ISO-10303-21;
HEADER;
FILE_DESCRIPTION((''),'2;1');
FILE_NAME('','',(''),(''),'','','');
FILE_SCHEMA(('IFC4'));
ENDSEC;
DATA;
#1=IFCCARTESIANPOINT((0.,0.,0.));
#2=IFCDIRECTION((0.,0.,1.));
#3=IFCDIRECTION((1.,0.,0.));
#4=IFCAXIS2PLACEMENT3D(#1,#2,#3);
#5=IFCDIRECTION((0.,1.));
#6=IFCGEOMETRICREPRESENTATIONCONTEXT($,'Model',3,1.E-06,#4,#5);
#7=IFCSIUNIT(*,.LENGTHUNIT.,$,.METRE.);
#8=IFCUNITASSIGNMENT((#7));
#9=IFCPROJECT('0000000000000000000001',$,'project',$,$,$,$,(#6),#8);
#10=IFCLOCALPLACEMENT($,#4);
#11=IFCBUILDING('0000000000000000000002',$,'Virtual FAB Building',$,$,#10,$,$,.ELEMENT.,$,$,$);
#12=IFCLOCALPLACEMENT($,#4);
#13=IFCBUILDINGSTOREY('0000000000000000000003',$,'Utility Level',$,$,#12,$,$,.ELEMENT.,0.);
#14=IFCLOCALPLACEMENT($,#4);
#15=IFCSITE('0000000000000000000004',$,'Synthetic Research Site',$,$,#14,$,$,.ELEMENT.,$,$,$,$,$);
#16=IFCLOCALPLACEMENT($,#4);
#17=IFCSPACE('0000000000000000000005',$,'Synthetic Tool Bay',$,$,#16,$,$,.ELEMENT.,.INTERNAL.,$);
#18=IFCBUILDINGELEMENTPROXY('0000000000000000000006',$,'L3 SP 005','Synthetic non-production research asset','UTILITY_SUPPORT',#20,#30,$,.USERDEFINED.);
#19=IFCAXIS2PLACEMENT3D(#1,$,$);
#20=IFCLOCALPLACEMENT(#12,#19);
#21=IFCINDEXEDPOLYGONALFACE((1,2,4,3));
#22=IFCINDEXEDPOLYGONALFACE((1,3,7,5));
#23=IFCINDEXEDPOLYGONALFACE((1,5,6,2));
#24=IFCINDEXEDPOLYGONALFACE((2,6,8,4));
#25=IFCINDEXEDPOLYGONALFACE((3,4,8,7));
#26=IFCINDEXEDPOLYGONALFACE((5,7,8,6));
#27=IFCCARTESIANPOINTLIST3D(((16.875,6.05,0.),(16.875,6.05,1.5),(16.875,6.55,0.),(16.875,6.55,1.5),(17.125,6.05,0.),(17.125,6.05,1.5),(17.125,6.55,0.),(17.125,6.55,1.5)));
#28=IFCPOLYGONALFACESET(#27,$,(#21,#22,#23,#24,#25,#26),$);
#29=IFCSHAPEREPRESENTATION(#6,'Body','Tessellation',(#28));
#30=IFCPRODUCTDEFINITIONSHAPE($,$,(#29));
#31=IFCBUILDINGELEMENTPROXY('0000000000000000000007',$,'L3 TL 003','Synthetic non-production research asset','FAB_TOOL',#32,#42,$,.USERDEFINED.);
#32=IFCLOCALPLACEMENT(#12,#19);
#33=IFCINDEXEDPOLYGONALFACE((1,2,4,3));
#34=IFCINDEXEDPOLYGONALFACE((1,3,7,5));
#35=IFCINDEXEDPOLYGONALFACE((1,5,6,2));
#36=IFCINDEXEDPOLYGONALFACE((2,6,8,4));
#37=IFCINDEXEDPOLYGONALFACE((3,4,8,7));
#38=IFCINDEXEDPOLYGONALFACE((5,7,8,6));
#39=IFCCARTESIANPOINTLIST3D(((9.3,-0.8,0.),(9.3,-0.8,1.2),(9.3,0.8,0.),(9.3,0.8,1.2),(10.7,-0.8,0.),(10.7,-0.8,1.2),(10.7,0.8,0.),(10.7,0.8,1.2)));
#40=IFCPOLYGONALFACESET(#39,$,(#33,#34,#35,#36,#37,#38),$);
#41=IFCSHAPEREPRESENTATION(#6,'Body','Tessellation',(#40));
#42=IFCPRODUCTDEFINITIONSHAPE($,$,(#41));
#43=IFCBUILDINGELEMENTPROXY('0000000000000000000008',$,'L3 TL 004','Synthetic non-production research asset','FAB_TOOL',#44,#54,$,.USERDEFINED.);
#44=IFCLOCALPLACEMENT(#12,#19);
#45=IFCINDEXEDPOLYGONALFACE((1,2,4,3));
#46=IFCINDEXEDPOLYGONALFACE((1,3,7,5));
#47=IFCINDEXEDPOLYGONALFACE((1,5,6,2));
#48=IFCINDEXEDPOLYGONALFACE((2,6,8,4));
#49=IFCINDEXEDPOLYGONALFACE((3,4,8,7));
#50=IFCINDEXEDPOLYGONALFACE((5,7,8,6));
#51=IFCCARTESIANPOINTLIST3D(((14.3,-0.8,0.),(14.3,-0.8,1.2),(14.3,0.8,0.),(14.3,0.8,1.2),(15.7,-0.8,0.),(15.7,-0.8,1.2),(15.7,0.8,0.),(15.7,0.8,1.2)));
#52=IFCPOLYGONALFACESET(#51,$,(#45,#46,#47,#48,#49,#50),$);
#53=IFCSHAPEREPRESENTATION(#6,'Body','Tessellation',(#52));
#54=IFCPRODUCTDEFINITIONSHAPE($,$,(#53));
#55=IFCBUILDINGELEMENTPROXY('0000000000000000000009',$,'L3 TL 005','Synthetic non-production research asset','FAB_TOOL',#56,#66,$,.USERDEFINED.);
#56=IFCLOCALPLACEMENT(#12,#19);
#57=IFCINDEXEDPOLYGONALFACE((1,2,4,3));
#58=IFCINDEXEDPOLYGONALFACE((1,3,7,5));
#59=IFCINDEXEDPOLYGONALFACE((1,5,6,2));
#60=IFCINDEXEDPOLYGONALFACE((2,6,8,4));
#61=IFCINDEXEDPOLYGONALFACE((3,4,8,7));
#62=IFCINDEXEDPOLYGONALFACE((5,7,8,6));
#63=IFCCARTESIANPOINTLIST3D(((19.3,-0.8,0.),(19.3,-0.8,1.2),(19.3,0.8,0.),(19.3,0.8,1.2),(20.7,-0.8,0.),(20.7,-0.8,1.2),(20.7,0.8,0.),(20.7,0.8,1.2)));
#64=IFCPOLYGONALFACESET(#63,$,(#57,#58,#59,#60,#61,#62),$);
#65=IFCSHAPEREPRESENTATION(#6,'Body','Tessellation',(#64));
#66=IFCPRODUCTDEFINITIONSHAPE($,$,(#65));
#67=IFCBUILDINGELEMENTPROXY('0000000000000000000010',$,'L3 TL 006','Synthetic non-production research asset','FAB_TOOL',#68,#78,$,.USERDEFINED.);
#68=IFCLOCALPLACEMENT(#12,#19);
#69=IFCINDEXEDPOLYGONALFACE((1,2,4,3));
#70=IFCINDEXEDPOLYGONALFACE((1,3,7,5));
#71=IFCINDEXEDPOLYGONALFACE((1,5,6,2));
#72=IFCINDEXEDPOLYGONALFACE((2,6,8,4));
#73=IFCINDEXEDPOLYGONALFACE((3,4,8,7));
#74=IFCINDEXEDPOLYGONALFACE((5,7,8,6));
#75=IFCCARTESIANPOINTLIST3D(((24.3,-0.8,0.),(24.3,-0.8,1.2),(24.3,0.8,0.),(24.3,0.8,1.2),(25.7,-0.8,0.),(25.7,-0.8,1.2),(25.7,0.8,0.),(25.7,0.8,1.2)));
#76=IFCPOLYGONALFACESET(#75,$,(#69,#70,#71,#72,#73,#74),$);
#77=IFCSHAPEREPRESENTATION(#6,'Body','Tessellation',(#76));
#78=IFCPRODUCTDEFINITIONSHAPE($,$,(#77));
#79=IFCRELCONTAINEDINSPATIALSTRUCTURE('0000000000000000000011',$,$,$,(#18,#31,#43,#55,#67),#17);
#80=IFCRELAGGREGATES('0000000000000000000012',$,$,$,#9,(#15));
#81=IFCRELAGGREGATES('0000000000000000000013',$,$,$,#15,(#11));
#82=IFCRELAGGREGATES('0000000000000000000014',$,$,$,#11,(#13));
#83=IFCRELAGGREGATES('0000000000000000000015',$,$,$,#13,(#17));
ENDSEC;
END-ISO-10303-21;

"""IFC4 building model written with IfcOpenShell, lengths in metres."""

from ifc_helpers import new_model, si_unit, direction, frame, origin_with_axes, origin_2d_with_axis, place, context, project, spatial, rectangle, extrude, element, save


model = new_model("IFC4")

# Units and contexts
model_context = context("Model", 3, precision=1e-06, world=origin_with_axes(), true_north=direction((0.0, 1.0)))
ifc_project = project(units=[si_unit("LENGTHUNIT", "METRE")], contexts=[model_context])

# Site, building, storey, space
site_placement = place(None, origin_with_axes())
site = spatial("IfcSite", under=ifc_project, at=site_placement, Name="Synthetic Research Site", CompositionType="ELEMENT")
building_placement = place(None, origin_with_axes())
building = spatial("IfcBuilding", under=site, at=building_placement, Name="Virtual FAB Building", CompositionType="ELEMENT")
storey_placement = place(None, origin_with_axes())
storey = spatial("IfcBuildingStorey", under=building, at=storey_placement, Name="Utility Level", CompositionType="ELEMENT", Elevation=0.0)
space_placement = place(None, origin_with_axes())
space = spatial("IfcSpace", under=storey, at=space_placement, Name="Synthetic Tool Bay", CompositionType="ELEMENT", PredefinedType="INTERNAL")

# Building element proxies
for number, where, z_axis, x_axis, name in (
    (1, (17.0, 6.3, 0.0), (0.0, 0.0, 1.0), (1.0, 0.0, 0.0), "L3 SP 005"),
):
    element("IfcBuildingElementProxy", number, at=place(None, frame(where, z_axis=z_axis, x_axis=x_axis)), inside=space, Name=name, Description="Synthetic non-production research asset", ObjectType="UTILITY_SUPPORT", PredefinedType="USERDEFINED", context=model_context, shape_type="SweptSolid", body=[
        extrude(rectangle(XDim=0.25, YDim=0.5, at=origin_2d_with_axis()), origin_with_axes(), (0.0, 0.0, 1.0), 1.5),
    ])
for number, where, z_axis, x_axis, name in (
    (2, (10.0, 0.0, 0.0), (0.0, 0.0, 1.0), (1.0, 0.0, 0.0), "L3 TL 003"),
    (3, (15.0, 0.0, 0.0), (0.0, 0.0, 1.0), (1.0, 0.0, 0.0), "L3 TL 004"),
    (4, (20.0, 0.0, 0.0), (0.0, 0.0, 1.0), (1.0, 0.0, 0.0), "L3 TL 005"),
    (5, (25.0, 0.0, 0.0), (0.0, 0.0, 1.0), (1.0, 0.0, 0.0), "L3 TL 006"),
):
    element("IfcBuildingElementProxy", number, at=place(None, frame(where, z_axis=z_axis, x_axis=x_axis)), inside=space, Name=name, Description="Synthetic non-production research asset", ObjectType="FAB_TOOL", PredefinedType="USERDEFINED", context=model_context, shape_type="SweptSolid", body=[
        extrude(rectangle(XDim=1.4, YDim=1.6, at=origin_2d_with_axis()), origin_with_axes(), (0.0, 0.0, 1.0), 1.2),
    ])

save(model, "model.ifc")
